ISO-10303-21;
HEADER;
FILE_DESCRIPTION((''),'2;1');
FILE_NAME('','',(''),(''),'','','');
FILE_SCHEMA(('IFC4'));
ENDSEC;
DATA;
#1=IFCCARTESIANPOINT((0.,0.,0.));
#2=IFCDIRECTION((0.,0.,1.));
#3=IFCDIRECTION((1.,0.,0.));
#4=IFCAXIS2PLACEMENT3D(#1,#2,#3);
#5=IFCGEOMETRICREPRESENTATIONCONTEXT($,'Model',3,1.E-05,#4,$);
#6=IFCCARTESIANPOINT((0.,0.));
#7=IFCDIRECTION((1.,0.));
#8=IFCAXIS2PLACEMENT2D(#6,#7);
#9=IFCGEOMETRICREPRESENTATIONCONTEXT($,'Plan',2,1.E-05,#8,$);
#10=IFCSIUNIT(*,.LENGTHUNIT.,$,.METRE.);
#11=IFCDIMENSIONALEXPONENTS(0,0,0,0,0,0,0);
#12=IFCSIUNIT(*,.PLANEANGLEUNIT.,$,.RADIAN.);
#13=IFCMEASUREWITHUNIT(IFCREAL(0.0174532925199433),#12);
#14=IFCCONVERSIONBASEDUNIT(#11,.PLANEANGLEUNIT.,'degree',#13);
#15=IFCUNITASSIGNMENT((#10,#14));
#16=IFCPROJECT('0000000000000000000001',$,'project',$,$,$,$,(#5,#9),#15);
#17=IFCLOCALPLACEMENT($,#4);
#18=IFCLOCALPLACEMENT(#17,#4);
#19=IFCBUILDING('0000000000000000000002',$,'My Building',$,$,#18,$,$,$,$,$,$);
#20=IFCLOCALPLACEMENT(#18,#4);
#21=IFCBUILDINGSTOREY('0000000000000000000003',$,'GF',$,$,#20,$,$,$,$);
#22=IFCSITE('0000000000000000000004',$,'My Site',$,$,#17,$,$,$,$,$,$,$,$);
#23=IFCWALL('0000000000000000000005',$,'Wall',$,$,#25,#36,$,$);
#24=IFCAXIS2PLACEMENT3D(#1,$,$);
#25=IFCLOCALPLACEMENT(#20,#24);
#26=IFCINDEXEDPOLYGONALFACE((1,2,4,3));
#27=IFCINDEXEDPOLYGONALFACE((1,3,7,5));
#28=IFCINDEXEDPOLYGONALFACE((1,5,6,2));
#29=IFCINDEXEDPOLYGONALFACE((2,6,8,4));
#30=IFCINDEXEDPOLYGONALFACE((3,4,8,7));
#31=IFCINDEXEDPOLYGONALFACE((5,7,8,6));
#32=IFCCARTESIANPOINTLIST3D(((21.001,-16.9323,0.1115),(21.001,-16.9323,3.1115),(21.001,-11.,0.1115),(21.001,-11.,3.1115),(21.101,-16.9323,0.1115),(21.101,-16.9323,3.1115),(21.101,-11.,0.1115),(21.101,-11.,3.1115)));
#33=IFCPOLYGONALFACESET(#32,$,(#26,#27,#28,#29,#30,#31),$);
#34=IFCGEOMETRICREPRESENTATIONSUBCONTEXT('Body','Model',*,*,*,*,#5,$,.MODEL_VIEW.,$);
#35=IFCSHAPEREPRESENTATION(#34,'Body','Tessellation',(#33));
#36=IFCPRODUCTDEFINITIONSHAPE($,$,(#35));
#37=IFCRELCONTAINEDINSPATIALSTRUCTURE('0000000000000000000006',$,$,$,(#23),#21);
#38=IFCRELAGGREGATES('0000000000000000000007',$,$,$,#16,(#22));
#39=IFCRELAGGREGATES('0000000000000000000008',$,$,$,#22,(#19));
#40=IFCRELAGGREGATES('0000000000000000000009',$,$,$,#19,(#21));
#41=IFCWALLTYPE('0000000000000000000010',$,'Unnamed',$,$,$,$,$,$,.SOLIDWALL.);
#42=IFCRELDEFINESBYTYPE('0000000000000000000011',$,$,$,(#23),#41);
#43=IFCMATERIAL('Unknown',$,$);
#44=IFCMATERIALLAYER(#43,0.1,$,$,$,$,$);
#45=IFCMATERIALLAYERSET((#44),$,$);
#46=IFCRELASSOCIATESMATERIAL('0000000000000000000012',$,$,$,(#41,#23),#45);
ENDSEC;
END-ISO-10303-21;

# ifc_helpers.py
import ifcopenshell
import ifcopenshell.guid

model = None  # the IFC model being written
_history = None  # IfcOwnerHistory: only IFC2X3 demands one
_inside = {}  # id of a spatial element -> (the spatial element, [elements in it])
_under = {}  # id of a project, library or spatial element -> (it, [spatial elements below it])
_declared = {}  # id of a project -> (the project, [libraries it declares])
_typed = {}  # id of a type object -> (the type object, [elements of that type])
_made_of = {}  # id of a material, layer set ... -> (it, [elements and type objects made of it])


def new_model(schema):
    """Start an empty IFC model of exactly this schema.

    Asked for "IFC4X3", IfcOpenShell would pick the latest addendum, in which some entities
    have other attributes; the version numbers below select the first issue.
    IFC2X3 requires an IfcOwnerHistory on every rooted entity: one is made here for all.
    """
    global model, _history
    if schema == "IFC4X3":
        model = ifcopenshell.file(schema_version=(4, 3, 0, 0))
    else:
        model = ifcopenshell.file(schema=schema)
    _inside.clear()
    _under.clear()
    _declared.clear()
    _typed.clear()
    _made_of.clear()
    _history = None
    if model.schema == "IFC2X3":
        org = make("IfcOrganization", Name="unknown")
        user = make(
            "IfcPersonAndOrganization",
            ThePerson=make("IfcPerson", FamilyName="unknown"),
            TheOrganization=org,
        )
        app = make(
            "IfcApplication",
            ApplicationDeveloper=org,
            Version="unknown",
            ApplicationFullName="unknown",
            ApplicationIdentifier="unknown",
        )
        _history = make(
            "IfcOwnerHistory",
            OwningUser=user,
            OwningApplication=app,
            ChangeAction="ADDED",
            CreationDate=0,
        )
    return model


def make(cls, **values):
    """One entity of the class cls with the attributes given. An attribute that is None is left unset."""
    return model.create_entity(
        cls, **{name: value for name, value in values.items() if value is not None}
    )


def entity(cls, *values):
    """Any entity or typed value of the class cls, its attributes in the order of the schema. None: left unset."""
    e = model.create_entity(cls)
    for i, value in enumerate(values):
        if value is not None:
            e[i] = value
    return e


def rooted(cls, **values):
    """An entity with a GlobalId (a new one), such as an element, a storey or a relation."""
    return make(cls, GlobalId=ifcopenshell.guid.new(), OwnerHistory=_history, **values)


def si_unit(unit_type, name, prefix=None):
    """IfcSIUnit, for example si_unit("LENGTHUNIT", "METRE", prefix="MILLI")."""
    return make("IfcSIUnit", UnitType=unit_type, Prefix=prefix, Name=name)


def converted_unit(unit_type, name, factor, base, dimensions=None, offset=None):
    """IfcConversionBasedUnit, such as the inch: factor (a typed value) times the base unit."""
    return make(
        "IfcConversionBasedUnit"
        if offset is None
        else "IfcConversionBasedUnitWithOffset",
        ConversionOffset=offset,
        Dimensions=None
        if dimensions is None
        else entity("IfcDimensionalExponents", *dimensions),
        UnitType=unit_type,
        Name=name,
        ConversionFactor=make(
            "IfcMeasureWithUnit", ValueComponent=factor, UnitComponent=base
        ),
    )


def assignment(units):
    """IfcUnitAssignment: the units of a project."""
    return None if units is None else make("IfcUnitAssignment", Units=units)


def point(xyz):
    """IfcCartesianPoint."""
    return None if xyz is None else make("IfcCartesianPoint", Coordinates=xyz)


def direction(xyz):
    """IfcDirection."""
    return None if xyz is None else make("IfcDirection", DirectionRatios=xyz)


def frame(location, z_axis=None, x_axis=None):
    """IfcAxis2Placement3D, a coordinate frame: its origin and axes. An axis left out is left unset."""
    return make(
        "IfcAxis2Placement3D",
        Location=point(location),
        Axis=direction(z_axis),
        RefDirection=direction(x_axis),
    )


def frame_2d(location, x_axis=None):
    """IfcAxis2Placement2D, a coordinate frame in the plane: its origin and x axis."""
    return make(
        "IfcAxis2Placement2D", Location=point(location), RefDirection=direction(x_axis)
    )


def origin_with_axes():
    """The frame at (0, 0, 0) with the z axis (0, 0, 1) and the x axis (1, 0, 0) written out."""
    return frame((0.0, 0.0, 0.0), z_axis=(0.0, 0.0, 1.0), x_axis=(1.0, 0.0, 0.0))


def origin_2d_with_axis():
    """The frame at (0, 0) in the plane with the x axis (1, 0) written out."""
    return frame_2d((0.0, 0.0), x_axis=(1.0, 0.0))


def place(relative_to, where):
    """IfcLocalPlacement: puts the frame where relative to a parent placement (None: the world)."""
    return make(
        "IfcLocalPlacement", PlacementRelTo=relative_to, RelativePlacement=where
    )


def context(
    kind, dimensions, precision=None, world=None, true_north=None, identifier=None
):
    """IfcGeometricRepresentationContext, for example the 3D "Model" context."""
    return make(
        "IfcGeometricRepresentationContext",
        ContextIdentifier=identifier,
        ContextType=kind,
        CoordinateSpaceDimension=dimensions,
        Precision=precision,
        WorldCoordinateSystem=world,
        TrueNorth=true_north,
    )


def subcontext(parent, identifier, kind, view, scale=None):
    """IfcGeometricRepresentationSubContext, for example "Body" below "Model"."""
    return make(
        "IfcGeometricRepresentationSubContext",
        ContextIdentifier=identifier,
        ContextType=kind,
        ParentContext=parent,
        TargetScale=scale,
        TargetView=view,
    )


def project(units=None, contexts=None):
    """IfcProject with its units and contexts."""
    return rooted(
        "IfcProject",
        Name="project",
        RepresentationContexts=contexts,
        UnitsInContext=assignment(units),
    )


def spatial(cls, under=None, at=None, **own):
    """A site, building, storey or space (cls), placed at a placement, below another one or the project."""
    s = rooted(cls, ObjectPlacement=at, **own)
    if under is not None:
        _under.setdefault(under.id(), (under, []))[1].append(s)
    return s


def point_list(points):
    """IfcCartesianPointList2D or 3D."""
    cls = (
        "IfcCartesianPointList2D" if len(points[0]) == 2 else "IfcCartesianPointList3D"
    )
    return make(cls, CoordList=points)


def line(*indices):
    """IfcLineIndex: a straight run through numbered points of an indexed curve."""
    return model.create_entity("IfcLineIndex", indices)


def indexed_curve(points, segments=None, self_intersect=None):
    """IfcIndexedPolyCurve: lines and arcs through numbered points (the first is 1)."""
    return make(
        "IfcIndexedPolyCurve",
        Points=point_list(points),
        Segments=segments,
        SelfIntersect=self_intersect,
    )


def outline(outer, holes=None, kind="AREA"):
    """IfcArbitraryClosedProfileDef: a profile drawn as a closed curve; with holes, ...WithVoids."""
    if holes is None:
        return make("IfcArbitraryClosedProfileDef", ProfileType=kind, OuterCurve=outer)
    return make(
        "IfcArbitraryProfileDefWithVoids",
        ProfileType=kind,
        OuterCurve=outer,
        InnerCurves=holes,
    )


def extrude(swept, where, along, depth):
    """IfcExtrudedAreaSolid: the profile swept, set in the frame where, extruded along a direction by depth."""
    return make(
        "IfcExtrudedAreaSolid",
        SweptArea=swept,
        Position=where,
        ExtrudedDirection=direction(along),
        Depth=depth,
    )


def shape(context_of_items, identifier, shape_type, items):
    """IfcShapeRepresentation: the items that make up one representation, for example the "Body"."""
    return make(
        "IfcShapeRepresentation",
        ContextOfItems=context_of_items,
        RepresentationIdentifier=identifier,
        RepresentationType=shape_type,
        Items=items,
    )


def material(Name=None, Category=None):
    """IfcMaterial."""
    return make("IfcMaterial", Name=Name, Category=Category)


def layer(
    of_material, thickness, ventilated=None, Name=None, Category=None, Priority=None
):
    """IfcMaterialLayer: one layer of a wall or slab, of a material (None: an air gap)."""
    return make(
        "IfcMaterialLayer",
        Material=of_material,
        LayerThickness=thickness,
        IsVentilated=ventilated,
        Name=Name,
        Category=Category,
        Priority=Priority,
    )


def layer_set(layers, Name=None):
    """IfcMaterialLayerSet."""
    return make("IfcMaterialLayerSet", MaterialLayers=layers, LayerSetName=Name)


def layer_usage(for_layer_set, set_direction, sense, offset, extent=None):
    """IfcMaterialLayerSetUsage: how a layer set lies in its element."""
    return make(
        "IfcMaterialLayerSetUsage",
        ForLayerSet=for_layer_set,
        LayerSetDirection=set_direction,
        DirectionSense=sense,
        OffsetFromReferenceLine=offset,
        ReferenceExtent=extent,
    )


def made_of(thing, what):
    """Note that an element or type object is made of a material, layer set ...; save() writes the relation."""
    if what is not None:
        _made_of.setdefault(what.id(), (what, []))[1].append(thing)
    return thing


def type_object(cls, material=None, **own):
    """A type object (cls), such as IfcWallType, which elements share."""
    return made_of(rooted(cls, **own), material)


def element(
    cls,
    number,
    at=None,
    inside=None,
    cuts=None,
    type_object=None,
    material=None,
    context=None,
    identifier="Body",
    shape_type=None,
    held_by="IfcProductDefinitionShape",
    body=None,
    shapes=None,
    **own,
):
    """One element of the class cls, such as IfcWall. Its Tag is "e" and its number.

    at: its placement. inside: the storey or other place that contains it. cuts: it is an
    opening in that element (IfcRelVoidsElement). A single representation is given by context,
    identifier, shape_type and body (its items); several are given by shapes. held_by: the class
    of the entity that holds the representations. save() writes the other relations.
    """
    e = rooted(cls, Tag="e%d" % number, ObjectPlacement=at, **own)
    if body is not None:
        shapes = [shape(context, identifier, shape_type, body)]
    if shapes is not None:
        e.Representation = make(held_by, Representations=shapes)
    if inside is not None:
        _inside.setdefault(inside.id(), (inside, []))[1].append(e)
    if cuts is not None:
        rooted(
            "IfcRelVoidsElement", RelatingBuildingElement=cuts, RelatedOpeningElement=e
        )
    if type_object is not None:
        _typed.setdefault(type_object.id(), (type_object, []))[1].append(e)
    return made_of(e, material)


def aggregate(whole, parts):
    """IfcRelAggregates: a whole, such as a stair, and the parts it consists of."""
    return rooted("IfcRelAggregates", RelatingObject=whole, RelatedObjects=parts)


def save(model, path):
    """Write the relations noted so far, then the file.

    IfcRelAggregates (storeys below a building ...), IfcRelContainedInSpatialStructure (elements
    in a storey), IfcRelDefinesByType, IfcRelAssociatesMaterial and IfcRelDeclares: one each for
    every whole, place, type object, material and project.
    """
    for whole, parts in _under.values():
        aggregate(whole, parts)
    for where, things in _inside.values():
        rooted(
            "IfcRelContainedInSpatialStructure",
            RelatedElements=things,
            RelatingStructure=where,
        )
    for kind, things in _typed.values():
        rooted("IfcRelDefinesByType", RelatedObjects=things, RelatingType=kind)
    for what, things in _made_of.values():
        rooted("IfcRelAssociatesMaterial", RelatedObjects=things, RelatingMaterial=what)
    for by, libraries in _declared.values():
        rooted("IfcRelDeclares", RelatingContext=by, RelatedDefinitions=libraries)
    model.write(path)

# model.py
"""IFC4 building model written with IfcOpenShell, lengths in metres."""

from ifc_helpers import new_model, entity, si_unit, converted_unit, frame, origin_with_axes, origin_2d_with_axis, place, context, subcontext, project, spatial, line, indexed_curve, outline, extrude, material, layer, layer_set, layer_usage, type_object, element, save


model = new_model("IFC4")

# Units and contexts
model_context = context("Model", 3, precision=1e-05, world=origin_with_axes())
plan_context = context("Plan", 2, precision=1e-05, world=origin_2d_with_axis())
body_context_1 = subcontext(model_context, "Body", "Model", "MODEL_VIEW")
ifc_project = project(units=[si_unit("LENGTHUNIT", "METRE"), converted_unit("PLANEANGLEUNIT", "degree", entity("IfcReal", 0.0174532925199433), si_unit("PLANEANGLEUNIT", "RADIAN"), dimensions=[0, 0, 0, 0, 0, 0, 0])], contexts=[model_context, plan_context])

# Site, building, storey
site_placement = place(None, origin_with_axes())
site = spatial("IfcSite", under=ifc_project, at=site_placement, Name="My Site")
building_placement = place(site_placement, origin_with_axes())
building = spatial("IfcBuilding", under=site, at=building_placement, Name="My Building")
storey_placement = place(building_placement, origin_with_axes())
storey = spatial("IfcBuildingStorey", under=building, at=storey_placement, Name="GF")

# Shared definitions
ifc_material = material(Name="Unknown")
ifc_layer = layer(ifc_material, 0.1)
ifc_layer_set = layer_set([ifc_layer])
wall_type = type_object("IfcWallType", Name="Unnamed", PredefinedType="SOLIDWALL", material=ifc_layer_set)

# Wall
ifc_layer_usage_1 = layer_usage(ifc_layer_set, "AXIS2", "POSITIVE", 0.0)
wall_1_placement = place(storey_placement, frame((21.101, -16.9323, 0.1115), z_axis=(0.0, 0.0, 1.0), x_axis=(0.0, 1.0, 0.0)))
element("IfcWall", 1, at=wall_1_placement, inside=storey, type_object=wall_type, material=ifc_layer_usage_1, Name="Wall", context=body_context_1, shape_type="SweptSolid", body=[
    extrude(outline(indexed_curve([(0.0, 0.0), (0.0, 0.1), (5.9323, 0.1), (5.9323, 0.0)], segments=[line(1, 2, 3, 4, 1)])), origin_with_axes(), (0.0, 0.0, 1.0), 3.0),
])

save(model, "model.ifc")
